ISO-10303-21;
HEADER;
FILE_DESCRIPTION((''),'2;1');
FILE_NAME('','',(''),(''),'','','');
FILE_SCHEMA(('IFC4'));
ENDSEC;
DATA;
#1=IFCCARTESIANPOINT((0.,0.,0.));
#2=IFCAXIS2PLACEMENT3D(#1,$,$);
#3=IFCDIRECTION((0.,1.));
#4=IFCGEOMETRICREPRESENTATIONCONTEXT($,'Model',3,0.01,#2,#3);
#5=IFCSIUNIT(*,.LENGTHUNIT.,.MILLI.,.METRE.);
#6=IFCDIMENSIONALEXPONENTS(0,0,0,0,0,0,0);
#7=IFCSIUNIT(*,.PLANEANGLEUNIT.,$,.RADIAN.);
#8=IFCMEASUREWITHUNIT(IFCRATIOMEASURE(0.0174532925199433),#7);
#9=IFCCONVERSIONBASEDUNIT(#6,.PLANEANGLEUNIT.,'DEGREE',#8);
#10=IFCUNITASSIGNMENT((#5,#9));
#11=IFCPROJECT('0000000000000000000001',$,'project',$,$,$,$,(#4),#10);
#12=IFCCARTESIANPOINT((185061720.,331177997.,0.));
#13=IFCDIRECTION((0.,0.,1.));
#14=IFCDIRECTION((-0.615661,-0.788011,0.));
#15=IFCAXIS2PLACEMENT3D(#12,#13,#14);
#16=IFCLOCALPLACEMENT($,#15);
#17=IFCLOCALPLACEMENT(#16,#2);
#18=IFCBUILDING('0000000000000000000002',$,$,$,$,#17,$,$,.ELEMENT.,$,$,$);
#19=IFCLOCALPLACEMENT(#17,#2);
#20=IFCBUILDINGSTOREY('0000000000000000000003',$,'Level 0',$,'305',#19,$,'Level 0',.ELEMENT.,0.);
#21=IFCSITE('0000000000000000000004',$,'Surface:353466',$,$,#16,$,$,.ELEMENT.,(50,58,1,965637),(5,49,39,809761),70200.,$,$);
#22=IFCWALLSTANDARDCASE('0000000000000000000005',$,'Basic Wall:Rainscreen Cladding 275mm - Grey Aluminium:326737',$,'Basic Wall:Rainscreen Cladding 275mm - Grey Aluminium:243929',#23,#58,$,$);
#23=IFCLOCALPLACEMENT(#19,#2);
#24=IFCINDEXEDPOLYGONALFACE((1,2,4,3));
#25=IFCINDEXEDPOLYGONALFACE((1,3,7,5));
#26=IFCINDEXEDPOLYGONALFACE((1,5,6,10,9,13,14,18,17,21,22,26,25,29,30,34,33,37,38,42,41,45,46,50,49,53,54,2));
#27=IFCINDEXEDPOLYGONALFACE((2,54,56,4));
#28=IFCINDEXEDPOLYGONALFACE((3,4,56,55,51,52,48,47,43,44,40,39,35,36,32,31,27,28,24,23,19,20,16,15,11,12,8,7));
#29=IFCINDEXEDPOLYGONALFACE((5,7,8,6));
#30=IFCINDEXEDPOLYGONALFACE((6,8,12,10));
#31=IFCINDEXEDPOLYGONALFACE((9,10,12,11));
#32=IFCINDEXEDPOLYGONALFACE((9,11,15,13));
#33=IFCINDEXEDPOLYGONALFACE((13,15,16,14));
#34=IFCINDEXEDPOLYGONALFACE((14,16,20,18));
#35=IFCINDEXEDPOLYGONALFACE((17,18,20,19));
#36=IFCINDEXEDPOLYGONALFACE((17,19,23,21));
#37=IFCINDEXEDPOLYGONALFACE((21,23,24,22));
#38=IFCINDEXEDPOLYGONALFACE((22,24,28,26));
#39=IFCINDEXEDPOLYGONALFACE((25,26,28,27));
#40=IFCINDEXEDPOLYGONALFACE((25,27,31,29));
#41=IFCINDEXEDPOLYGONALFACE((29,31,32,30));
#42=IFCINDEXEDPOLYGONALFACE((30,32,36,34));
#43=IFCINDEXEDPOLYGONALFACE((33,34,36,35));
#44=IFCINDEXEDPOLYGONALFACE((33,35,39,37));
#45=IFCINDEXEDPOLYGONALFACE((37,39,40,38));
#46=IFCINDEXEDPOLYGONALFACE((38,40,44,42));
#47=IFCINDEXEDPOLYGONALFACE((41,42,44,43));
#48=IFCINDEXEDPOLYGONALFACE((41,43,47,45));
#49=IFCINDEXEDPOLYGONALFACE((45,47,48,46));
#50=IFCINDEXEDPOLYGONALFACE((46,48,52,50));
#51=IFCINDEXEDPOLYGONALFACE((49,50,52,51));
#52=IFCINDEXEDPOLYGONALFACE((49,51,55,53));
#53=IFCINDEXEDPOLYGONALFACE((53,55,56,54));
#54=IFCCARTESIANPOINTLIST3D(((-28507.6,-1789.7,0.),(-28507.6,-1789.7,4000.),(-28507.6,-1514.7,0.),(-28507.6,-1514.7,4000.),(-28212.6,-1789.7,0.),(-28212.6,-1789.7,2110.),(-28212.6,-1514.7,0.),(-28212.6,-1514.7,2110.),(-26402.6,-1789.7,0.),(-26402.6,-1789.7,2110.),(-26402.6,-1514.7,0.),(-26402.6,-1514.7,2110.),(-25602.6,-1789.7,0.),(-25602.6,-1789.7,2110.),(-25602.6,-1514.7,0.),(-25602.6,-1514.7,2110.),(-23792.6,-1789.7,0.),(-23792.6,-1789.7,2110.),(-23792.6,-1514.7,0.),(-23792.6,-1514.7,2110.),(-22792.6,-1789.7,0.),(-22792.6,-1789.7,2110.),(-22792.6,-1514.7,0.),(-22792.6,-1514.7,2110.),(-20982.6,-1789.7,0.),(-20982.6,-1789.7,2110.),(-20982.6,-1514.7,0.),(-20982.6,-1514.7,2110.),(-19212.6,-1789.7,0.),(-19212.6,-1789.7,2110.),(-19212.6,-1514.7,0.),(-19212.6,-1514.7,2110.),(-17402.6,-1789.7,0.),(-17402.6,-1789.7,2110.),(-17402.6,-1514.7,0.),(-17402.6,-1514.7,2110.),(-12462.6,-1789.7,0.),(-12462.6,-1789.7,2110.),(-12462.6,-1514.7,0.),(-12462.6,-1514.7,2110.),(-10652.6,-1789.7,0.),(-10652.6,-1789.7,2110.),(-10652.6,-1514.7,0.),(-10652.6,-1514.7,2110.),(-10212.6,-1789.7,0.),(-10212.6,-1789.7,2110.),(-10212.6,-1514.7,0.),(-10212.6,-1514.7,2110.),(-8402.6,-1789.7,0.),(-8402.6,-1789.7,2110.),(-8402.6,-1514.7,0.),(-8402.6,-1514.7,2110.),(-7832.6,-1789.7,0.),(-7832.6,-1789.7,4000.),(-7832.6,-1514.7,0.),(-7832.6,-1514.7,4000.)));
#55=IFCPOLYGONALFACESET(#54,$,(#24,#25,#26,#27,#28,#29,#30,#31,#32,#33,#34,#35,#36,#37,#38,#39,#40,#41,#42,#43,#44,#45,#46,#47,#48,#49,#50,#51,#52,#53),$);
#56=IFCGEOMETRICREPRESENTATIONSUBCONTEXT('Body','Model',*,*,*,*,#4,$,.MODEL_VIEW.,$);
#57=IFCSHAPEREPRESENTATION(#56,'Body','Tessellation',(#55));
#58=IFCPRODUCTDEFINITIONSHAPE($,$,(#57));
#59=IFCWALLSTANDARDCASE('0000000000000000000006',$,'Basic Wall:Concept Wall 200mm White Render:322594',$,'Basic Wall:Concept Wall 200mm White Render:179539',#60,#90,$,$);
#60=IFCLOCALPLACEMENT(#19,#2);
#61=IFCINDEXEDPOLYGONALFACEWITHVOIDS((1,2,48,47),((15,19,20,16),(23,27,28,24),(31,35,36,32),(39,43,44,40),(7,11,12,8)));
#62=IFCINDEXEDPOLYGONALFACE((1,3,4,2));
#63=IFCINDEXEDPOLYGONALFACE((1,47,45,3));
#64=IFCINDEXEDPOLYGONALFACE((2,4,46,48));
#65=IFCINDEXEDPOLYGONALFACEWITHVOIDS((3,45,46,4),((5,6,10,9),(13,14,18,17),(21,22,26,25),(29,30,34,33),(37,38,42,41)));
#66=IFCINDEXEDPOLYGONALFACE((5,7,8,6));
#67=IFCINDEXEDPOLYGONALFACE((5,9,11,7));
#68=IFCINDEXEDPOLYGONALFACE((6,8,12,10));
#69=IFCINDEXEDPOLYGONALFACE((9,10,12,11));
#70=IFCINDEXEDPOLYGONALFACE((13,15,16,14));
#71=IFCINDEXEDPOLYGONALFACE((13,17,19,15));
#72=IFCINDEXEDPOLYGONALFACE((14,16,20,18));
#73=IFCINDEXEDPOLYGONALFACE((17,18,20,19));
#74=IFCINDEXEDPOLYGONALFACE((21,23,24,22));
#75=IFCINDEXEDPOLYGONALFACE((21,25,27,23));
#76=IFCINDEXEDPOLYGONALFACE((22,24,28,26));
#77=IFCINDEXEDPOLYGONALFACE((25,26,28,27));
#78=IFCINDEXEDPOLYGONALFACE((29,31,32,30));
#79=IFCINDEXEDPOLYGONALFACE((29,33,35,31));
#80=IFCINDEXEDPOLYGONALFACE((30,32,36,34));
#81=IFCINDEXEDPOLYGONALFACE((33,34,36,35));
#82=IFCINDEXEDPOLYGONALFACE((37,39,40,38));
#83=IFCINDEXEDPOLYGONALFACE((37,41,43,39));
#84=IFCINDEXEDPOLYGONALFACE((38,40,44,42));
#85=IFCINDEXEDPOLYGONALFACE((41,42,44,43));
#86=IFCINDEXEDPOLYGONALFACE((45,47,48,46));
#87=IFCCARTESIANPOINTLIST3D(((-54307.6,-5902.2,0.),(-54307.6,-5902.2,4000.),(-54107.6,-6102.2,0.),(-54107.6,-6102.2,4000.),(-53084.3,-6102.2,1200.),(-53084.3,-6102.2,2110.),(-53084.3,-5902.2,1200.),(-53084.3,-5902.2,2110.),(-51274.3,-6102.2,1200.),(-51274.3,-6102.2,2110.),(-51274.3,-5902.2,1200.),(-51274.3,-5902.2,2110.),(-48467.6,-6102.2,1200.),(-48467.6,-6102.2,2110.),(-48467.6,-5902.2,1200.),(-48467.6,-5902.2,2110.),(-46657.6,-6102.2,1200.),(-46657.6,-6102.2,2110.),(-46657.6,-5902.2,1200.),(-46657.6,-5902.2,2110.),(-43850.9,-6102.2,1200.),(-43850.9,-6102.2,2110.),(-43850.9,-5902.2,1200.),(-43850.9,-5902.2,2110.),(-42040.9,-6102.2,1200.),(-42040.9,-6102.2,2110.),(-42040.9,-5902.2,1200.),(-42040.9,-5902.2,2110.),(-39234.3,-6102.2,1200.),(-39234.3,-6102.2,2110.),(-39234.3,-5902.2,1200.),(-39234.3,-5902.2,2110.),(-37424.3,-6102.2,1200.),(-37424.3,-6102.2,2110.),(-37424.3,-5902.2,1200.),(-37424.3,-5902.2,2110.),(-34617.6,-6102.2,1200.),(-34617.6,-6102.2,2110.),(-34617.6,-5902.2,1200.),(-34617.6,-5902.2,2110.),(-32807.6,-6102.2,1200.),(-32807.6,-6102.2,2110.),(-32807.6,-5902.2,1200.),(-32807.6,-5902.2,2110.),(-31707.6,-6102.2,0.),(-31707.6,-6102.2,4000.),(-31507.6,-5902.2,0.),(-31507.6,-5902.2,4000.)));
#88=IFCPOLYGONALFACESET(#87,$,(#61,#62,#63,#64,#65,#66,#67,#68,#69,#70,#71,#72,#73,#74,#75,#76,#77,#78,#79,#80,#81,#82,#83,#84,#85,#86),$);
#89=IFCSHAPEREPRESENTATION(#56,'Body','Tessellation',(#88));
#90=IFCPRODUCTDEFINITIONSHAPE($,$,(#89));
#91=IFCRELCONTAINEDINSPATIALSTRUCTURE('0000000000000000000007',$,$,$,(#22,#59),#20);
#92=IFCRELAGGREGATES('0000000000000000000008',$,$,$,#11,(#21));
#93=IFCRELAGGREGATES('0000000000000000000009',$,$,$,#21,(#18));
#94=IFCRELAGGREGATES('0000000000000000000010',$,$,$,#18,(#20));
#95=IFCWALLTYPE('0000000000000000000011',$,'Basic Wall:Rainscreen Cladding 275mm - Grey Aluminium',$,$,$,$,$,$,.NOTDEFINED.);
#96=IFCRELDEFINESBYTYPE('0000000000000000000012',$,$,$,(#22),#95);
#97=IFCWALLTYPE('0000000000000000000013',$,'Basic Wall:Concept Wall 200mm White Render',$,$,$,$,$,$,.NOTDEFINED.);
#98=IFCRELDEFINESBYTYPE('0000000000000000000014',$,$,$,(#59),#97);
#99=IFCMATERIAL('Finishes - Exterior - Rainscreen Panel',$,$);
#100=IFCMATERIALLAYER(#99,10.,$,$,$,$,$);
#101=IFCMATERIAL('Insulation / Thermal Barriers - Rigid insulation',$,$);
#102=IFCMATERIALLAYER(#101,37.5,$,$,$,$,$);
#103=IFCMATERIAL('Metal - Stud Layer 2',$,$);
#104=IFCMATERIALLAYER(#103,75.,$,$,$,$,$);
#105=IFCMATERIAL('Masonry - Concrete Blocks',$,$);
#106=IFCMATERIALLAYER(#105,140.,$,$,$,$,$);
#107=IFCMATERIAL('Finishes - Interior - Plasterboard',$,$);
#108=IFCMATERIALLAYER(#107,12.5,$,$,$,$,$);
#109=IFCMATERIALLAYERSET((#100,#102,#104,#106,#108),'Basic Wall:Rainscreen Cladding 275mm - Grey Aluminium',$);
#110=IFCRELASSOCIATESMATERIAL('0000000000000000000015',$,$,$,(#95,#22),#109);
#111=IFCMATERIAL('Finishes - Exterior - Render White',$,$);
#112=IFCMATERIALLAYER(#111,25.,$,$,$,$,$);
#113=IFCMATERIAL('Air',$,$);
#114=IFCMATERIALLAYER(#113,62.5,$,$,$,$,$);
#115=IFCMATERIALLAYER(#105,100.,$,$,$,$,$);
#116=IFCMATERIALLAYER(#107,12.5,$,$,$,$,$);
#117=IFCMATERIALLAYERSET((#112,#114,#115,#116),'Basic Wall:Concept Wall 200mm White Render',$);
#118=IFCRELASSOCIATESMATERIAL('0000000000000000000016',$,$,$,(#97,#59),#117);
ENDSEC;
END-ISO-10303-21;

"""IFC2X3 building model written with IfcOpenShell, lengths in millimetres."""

from ifc_helpers import new_model, entity, si_unit, converted_unit, direction, frame, frame_2d, origin, place, context, subcontext, project, spatial, polyline, rectangle, outline, extrude, clip, halfspace, material, layer, layer_set, layer_usage, type_object, element, save


model = new_model("IFC2X3")

# Units and contexts
model_context = context("Model", 3, precision=0.01, world=origin(), true_north=direction((0.0, 1.0)))
body_context = subcontext(model_context, "Body", "Model", "MODEL_VIEW")
ifc_project = project(units=[si_unit("LENGTHUNIT", "METRE", prefix="MILLI"), converted_unit("PLANEANGLEUNIT", "DEGREE", entity("IfcRatioMeasure", 0.0174532925199433), si_unit("PLANEANGLEUNIT", "RADIAN"), dimensions=[0, 0, 0, 0, 0, 0, 0])], contexts=[model_context])

# Site, building, storey
site_placement = place(None, frame((185061720.0, 331177997.0, 0.0), z_axis=(0.0, 0.0, 1.0), x_axis=(-0.615661, -0.788011, 0.0)))
site = spatial("IfcSite", under=ifc_project, at=site_placement, Name="Surface:353466", CompositionType="ELEMENT", RefLatitude=(50, 58, 1, 965637), RefLongitude=(5, 49, 39, 809761), RefElevation=70200.0)
building_placement = place(site_placement, origin())
building = spatial("IfcBuilding", under=site, at=building_placement, CompositionType="ELEMENT")
storey_placement = place(building_placement, origin())
storey = spatial("IfcBuildingStorey", under=building, at=storey_placement, Name="Level 0", ObjectType="305", LongName="Level 0", CompositionType="ELEMENT", Elevation=0.0)

# Walls, openings
ifc_material_1 = material(Name="Finishes - Exterior - Rainscreen Panel")
ifc_layer_1 = layer(ifc_material_1, 10.0)
ifc_material_2 = material(Name="Insulation / Thermal Barriers - Rigid insulation")
ifc_layer_2 = layer(ifc_material_2, 37.5)
ifc_material_3 = material(Name="Metal - Stud Layer 2")
ifc_layer_3 = layer(ifc_material_3, 75.0)
ifc_material_4 = material(Name="Masonry - Concrete Blocks")
ifc_layer_4 = layer(ifc_material_4, 140.0)
ifc_material_5 = material(Name="Finishes - Interior - Plasterboard")
ifc_layer_5 = layer(ifc_material_5, 12.5)
ifc_layer_set_1 = layer_set([ifc_layer_1, ifc_layer_2, ifc_layer_3, ifc_layer_4, ifc_layer_5], Name="Basic Wall:Rainscreen Cladding 275mm - Grey Aluminium")
ifc_layer_usage_1 = layer_usage(ifc_layer_set_1, "AXIS2", "NEGATIVE", 137.5)
wall_type_1 = type_object("IfcWallType", Name="Basic Wall:Rainscreen Cladding 275mm - Grey Aluminium", PredefinedType="NOTDEFINED", material=ifc_layer_set_1)
wall_1_placement = place(storey_placement, frame((-28507.6, -1652.2, 0.0)))
wall_1 = element("IfcWallStandardCase", 1, at=wall_1_placement, inside=storey, type_object=wall_type_1, material=ifc_layer_usage_1, Name="Basic Wall:Rainscreen Cladding 275mm - Grey Aluminium:326737", ObjectType="Basic Wall:Rainscreen Cladding 275mm - Grey Aluminium:243929", context=body_context, shape_type="Clipping", body=[
    clip(extrude(rectangle(XDim=20675.0, YDim=275.0, at=frame_2d((10337.5, 0.0), x_axis=(-1.0, 0.0))), origin(), (0.0, 0.0, 1.0), 4000.0), halfspace(origin(), True)),
])
opening_1_placement = place(wall_1_placement, origin())
element("IfcOpeningElement", 2, at=opening_1_placement, cuts=wall_1, ObjectType="Opening", context=body_context, shape_type="SweptSolid", body=[
    extrude(rectangle(XDim=2110.0, YDim=1810.0, at=frame_2d((0.0, 0.0), x_axis=(0.0, 1.0))), frame((10200.0, -1661.5, 1055.0), z_axis=(0.0, 1.0, 0.0), x_axis=(1.0, 0.0, 0.0)), (0.0, 0.0, 1.0), 3048.0),
])
opening_2_placement = place(wall_1_placement, origin())
element("IfcOpeningElement", 3, at=opening_2_placement, cuts=wall_1, ObjectType="Opening", context=body_context, shape_type="SweptSolid", body=[
    extrude(rectangle(XDim=2110.0, YDim=1810.0, at=frame_2d((0.0, 0.0), x_axis=(0.0, 1.0))), frame((16950.0, -1661.5, 1055.0), z_axis=(0.0, 1.0, 0.0), x_axis=(1.0, 0.0, 0.0)), (0.0, 0.0, 1.0), 3048.0),
])
opening_3_placement = place(wall_1_placement, origin())
element("IfcOpeningElement", 4, at=opening_3_placement, cuts=wall_1, ObjectType="Opening", context=body_context, shape_type="SweptSolid", body=[
    extrude(rectangle(XDim=2110.0, YDim=1810.0, at=frame_2d((0.0, 0.0), x_axis=(0.0, 1.0))), frame((19200.0, -1661.5, 1055.0), z_axis=(0.0, 1.0, 0.0), x_axis=(1.0, 0.0, 0.0)), (0.0, 0.0, 1.0), 3048.0),
])
opening_4_placement = place(wall_1_placement, origin())
element("IfcOpeningElement", 5, at=opening_4_placement, cuts=wall_1, ObjectType="Opening", context=body_context, shape_type="SweptSolid", body=[
    extrude(rectangle(XDim=2110.0, YDim=1810.0, at=frame_2d((0.0, 0.0), x_axis=(0.0, 1.0))), frame((1200.0, -1661.5, 1055.0), z_axis=(0.0, 1.0, 0.0), x_axis=(1.0, 0.0, 0.0)), (0.0, 0.0, 1.0), 3048.0),
])
opening_5_placement = place(wall_1_placement, origin())
element("IfcOpeningElement", 6, at=opening_5_placement, cuts=wall_1, ObjectType="Opening", context=body_context, shape_type="SweptSolid", body=[
    extrude(rectangle(XDim=2110.0, YDim=1810.0, at=frame_2d((0.0, 0.0), x_axis=(0.0, 1.0))), frame((3810.0, -1661.5, 1055.0), z_axis=(0.0, 1.0, 0.0), x_axis=(1.0, 0.0, 0.0)), (0.0, 0.0, 1.0), 3048.0),
])
opening_6_placement = place(wall_1_placement, origin())
element("IfcOpeningElement", 7, at=opening_6_placement, cuts=wall_1, ObjectType="Opening", context=body_context, shape_type="SweptSolid", body=[
    extrude(rectangle(XDim=2110.0, YDim=1810.0, at=frame_2d((0.0, 0.0), x_axis=(0.0, 1.0))), frame((6620.0, -1661.5, 1055.0), z_axis=(0.0, 1.0, 0.0), x_axis=(1.0, 0.0, 0.0)), (0.0, 0.0, 1.0), 3048.0),
])
opening_7_placement = place(wall_1_placement, frame((11105.0, 137.5, 0.0)))
element("IfcOpeningElement", 8, at=opening_7_placement, cuts=wall_1, ObjectType="Opening", context=body_context, shape_type="SweptSolid", body=[
    extrude(rectangle(XDim=2110.0, YDim=1810.0, at=frame_2d((1055.0, 905.0), x_axis=(-1.0, 0.0))), frame((0.0, 0.0, 0.0), z_axis=(0.0, -1.0, 0.0), x_axis=(0.0, 0.0, 1.0)), (0.0, 0.0, 1.0), 275.0),
])
opening_8_placement = place(wall_1_placement, frame((17855.0, 137.5, 0.0)))
element("IfcOpeningElement", 9, at=opening_8_placement, cuts=wall_1, ObjectType="Opening", context=body_context, shape_type="SweptSolid", body=[
    extrude(rectangle(XDim=2110.0, YDim=1810.0, at=frame_2d((1055.0, 905.0), x_axis=(-1.0, 0.0))), frame((0.0, 0.0, 0.0), z_axis=(0.0, -1.0, 0.0), x_axis=(0.0, 0.0, 1.0)), (0.0, 0.0, 1.0), 275.0),
])
opening_9_placement = place(wall_1_placement, frame((20105.0, 137.5, 0.0)))
element("IfcOpeningElement", 10, at=opening_9_placement, cuts=wall_1, ObjectType="Opening", context=body_context, shape_type="SweptSolid", body=[
    extrude(rectangle(XDim=2110.0, YDim=1810.0, at=frame_2d((1055.0, 905.0), x_axis=(-1.0, 0.0))), frame((0.0, 0.0, 0.0), z_axis=(0.0, -1.0, 0.0), x_axis=(0.0, 0.0, 1.0)), (0.0, 0.0, 1.0), 275.0),
])
opening_10_placement = place(wall_1_placement, frame((4715.0, 137.5, 0.0)))
element("IfcOpeningElement", 11, at=opening_10_placement, cuts=wall_1, ObjectType="Opening", context=body_context, shape_type="SweptSolid", body=[
    extrude(rectangle(XDim=2110.0, YDim=1810.0, at=frame_2d((1055.0, 905.0), x_axis=(-1.0, 0.0))), frame((0.0, 0.0, 0.0), z_axis=(0.0, -1.0, 0.0), x_axis=(0.0, 0.0, 1.0)), (0.0, 0.0, 1.0), 275.0),
])
opening_11_placement = place(wall_1_placement, frame((2105.0, 137.5, 0.0)))
element("IfcOpeningElement", 12, at=opening_11_placement, cuts=wall_1, ObjectType="Opening", context=body_context, shape_type="SweptSolid", body=[
    extrude(rectangle(XDim=2110.0, YDim=1810.0, at=frame_2d((1055.0, 905.0), x_axis=(-1.0, 0.0))), frame((0.0, 0.0, 0.0), z_axis=(0.0, -1.0, 0.0), x_axis=(0.0, 0.0, 1.0)), (0.0, 0.0, 1.0), 275.0),
])
opening_12_placement = place(wall_1_placement, frame((7525.0, 137.5, 0.0)))
element("IfcOpeningElement", 13, at=opening_12_placement, cuts=wall_1, ObjectType="Opening", context=body_context, shape_type="SweptSolid", body=[
    extrude(rectangle(XDim=2110.0, YDim=1810.0, at=frame_2d((1055.0, 905.0), x_axis=(-1.0, 0.0))), frame((0.0, 0.0, 0.0), z_axis=(0.0, -1.0, 0.0), x_axis=(0.0, 0.0, 1.0)), (0.0, 0.0, 1.0), 275.0),
])
ifc_material_6 = material(Name="Finishes - Exterior - Render White")
ifc_layer_6 = layer(ifc_material_6, 25.0)
ifc_material_7 = material(Name="Air")
ifc_layer_7 = layer(ifc_material_7, 62.5)
ifc_layer_8 = layer(ifc_material_4, 100.0)
ifc_layer_9 = layer(ifc_material_5, 12.5)
ifc_layer_set_2 = layer_set([ifc_layer_6, ifc_layer_7, ifc_layer_8, ifc_layer_9], Name="Basic Wall:Concept Wall 200mm White Render")
ifc_layer_usage_2 = layer_usage(ifc_layer_set_2, "AXIS2", "POSITIVE", -100.0)
wall_type_2 = type_object("IfcWallType", Name="Basic Wall:Concept Wall 200mm White Render", PredefinedType="NOTDEFINED", material=ifc_layer_set_2)
wall_2_placement = place(storey_placement, frame((-31507.6, -6002.2, 0.0), z_axis=(0.0, 0.0, 1.0), x_axis=(-1.0, 0.0, 0.0)))
wall_2 = element("IfcWallStandardCase", 14, at=wall_2_placement, inside=storey, type_object=wall_type_2, material=ifc_layer_usage_2, Name="Basic Wall:Concept Wall 200mm White Render:322594", ObjectType="Basic Wall:Concept Wall 200mm White Render:179539", context=body_context, shape_type="Clipping", body=[
    clip(extrude(outline(polyline([(22800.0, -100.0), (22600.0, 100.0), (13722.5, 100.0), (13557.5, 100.0), (5162.5, 100.0), (4997.5, 100.0), (200.0, 100.0), (0.0, -100.0), (22800.0, -100.0)])), origin(), (0.0, 0.0, 1.0), 4000.0), halfspace(origin(), True)),
])
opening_13_placement = place(wall_2_placement, origin())
element("IfcOpeningElement", 15, at=opening_13_placement, cuts=wall_2, ObjectType="Opening", context=body_context, shape_type="SweptSolid", body=[
    extrude(rectangle(XDim=910.0, YDim=1810.0, at=frame_2d((0.0, 0.0), x_axis=(1.0, 0.0))), frame((2205.0, -1424.0, 1655.0), z_axis=(0.0, 1.0, 0.0), x_axis=(0.0, 0.0, -1.0)), (0.0, 0.0, 1.0), 3048.0),
])
opening_14_placement = place(wall_2_placement, origin())
element("IfcOpeningElement", 16, at=opening_14_placement, cuts=wall_2, ObjectType="Opening", context=body_context, shape_type="SweptSolid", body=[
    extrude(rectangle(XDim=910.0, YDim=1810.0, at=frame_2d((0.0, 0.0), x_axis=(1.0, 0.0))), frame((6821.7, -1424.0, 1655.0), z_axis=(0.0, 1.0, 0.0), x_axis=(0.0, 0.0, -1.0)), (0.0, 0.0, 1.0), 3048.0),
])
opening_15_placement = place(wall_2_placement, origin())
element("IfcOpeningElement", 17, at=opening_15_placement, cuts=wall_2, ObjectType="Opening", context=body_context, shape_type="SweptSolid", body=[
    extrude(rectangle(XDim=910.0, YDim=1810.0, at=frame_2d((0.0, 0.0), x_axis=(1.0, 0.0))), frame((16055.0, -1424.0, 1655.0), z_axis=(0.0, 1.0, 0.0), x_axis=(0.0, 0.0, -1.0)), (0.0, 0.0, 1.0), 3048.0),
])
opening_16_placement = place(wall_2_placement, origin())
element("IfcOpeningElement", 18, at=opening_16_placement, cuts=wall_2, ObjectType="Opening", context=body_context, shape_type="SweptSolid", body=[
    extrude(rectangle(XDim=910.0, YDim=1810.0, at=frame_2d((0.0, 0.0), x_axis=(1.0, 0.0))), frame((11438.4, -1424.0, 1655.0), z_axis=(0.0, 1.0, 0.0), x_axis=(0.0, 0.0, -1.0)), (0.0, 0.0, 1.0), 3048.0),
])
opening_17_placement = place(wall_2_placement, origin())
element("IfcOpeningElement", 19, at=opening_17_placement, cuts=wall_2, ObjectType="Opening", context=body_context, shape_type="SweptSolid", body=[
    extrude(rectangle(XDim=910.0, YDim=1810.0, at=frame_2d((0.0, 0.0), x_axis=(1.0, 0.0))), frame((20671.7, -1424.0, 1655.0), z_axis=(0.0, 1.0, 0.0), x_axis=(0.0, 0.0, -1.0)), (0.0, 0.0, 1.0), 3048.0),
])
opening_18_placement = place(wall_2_placement, frame((3110.0, 100.0, 1200.0)))
element("IfcOpeningElement", 20, at=opening_18_placement, cuts=wall_2, ObjectType="Opening", context=body_context, shape_type="SweptSolid", body=[
    extrude(rectangle(XDim=910.0, YDim=1810.0, at=frame_2d((455.0, 905.0), x_axis=(-1.0, 0.0))), frame((0.0, 0.0, 0.0), z_axis=(0.0, -1.0, 0.0), x_axis=(0.0, 0.0, 1.0)), (0.0, 0.0, 1.0), 200.0),
])
opening_19_placement = place(wall_2_placement, frame((7726.7, 100.0, 1200.0)))
element("IfcOpeningElement", 21, at=opening_19_placement, cuts=wall_2, ObjectType="Opening", context=body_context, shape_type="SweptSolid", body=[
    extrude(rectangle(XDim=910.0, YDim=1810.0, at=frame_2d((455.0, 905.0), x_axis=(-1.0, 0.0))), frame((0.0, 0.0, 0.0), z_axis=(0.0, -1.0, 0.0), x_axis=(0.0, 0.0, 1.0)), (0.0, 0.0, 1.0), 200.0),
])
opening_20_placement = place(wall_2_placement, frame((12343.4, 100.0, 1200.0)))
element("IfcOpeningElement", 22, at=opening_20_placement, cuts=wall_2, ObjectType="Opening", context=body_context, shape_type="SweptSolid", body=[
    extrude(rectangle(XDim=910.0, YDim=1810.0, at=frame_2d((455.0, 905.0), x_axis=(-1.0, 0.0))), frame((0.0, 0.0, 0.0), z_axis=(0.0, -1.0, 0.0), x_axis=(0.0, 0.0, 1.0)), (0.0, 0.0, 1.0), 200.0),
])
opening_21_placement = place(wall_2_placement, frame((16960.0, 100.0, 1200.0)))
element("IfcOpeningElement", 23, at=opening_21_placement, cuts=wall_2, ObjectType="Opening", context=body_context, shape_type="SweptSolid", body=[
    extrude(rectangle(XDim=910.0, YDim=1810.0, at=frame_2d((455.0, 905.0), x_axis=(-1.0, 0.0))), frame((0.0, 0.0, 0.0), z_axis=(0.0, -1.0, 0.0), x_axis=(0.0, 0.0, 1.0)), (0.0, 0.0, 1.0), 200.0),
])
opening_22_placement = place(wall_2_placement, frame((21576.7, 100.0, 1200.0)))
element("IfcOpeningElement", 24, at=opening_22_placement, cuts=wall_2, ObjectType="Opening", context=body_context, shape_type="SweptSolid", body=[
    extrude(rectangle(XDim=910.0, YDim=1810.0, at=frame_2d((455.0, 905.0), x_axis=(-1.0, 0.0))), frame((0.0, 0.0, 0.0), z_axis=(0.0, -1.0, 0.0), x_axis=(0.0, 0.0, 1.0)), (0.0, 0.0, 1.0), 200.0),
])

save(model, "model.ifc")
